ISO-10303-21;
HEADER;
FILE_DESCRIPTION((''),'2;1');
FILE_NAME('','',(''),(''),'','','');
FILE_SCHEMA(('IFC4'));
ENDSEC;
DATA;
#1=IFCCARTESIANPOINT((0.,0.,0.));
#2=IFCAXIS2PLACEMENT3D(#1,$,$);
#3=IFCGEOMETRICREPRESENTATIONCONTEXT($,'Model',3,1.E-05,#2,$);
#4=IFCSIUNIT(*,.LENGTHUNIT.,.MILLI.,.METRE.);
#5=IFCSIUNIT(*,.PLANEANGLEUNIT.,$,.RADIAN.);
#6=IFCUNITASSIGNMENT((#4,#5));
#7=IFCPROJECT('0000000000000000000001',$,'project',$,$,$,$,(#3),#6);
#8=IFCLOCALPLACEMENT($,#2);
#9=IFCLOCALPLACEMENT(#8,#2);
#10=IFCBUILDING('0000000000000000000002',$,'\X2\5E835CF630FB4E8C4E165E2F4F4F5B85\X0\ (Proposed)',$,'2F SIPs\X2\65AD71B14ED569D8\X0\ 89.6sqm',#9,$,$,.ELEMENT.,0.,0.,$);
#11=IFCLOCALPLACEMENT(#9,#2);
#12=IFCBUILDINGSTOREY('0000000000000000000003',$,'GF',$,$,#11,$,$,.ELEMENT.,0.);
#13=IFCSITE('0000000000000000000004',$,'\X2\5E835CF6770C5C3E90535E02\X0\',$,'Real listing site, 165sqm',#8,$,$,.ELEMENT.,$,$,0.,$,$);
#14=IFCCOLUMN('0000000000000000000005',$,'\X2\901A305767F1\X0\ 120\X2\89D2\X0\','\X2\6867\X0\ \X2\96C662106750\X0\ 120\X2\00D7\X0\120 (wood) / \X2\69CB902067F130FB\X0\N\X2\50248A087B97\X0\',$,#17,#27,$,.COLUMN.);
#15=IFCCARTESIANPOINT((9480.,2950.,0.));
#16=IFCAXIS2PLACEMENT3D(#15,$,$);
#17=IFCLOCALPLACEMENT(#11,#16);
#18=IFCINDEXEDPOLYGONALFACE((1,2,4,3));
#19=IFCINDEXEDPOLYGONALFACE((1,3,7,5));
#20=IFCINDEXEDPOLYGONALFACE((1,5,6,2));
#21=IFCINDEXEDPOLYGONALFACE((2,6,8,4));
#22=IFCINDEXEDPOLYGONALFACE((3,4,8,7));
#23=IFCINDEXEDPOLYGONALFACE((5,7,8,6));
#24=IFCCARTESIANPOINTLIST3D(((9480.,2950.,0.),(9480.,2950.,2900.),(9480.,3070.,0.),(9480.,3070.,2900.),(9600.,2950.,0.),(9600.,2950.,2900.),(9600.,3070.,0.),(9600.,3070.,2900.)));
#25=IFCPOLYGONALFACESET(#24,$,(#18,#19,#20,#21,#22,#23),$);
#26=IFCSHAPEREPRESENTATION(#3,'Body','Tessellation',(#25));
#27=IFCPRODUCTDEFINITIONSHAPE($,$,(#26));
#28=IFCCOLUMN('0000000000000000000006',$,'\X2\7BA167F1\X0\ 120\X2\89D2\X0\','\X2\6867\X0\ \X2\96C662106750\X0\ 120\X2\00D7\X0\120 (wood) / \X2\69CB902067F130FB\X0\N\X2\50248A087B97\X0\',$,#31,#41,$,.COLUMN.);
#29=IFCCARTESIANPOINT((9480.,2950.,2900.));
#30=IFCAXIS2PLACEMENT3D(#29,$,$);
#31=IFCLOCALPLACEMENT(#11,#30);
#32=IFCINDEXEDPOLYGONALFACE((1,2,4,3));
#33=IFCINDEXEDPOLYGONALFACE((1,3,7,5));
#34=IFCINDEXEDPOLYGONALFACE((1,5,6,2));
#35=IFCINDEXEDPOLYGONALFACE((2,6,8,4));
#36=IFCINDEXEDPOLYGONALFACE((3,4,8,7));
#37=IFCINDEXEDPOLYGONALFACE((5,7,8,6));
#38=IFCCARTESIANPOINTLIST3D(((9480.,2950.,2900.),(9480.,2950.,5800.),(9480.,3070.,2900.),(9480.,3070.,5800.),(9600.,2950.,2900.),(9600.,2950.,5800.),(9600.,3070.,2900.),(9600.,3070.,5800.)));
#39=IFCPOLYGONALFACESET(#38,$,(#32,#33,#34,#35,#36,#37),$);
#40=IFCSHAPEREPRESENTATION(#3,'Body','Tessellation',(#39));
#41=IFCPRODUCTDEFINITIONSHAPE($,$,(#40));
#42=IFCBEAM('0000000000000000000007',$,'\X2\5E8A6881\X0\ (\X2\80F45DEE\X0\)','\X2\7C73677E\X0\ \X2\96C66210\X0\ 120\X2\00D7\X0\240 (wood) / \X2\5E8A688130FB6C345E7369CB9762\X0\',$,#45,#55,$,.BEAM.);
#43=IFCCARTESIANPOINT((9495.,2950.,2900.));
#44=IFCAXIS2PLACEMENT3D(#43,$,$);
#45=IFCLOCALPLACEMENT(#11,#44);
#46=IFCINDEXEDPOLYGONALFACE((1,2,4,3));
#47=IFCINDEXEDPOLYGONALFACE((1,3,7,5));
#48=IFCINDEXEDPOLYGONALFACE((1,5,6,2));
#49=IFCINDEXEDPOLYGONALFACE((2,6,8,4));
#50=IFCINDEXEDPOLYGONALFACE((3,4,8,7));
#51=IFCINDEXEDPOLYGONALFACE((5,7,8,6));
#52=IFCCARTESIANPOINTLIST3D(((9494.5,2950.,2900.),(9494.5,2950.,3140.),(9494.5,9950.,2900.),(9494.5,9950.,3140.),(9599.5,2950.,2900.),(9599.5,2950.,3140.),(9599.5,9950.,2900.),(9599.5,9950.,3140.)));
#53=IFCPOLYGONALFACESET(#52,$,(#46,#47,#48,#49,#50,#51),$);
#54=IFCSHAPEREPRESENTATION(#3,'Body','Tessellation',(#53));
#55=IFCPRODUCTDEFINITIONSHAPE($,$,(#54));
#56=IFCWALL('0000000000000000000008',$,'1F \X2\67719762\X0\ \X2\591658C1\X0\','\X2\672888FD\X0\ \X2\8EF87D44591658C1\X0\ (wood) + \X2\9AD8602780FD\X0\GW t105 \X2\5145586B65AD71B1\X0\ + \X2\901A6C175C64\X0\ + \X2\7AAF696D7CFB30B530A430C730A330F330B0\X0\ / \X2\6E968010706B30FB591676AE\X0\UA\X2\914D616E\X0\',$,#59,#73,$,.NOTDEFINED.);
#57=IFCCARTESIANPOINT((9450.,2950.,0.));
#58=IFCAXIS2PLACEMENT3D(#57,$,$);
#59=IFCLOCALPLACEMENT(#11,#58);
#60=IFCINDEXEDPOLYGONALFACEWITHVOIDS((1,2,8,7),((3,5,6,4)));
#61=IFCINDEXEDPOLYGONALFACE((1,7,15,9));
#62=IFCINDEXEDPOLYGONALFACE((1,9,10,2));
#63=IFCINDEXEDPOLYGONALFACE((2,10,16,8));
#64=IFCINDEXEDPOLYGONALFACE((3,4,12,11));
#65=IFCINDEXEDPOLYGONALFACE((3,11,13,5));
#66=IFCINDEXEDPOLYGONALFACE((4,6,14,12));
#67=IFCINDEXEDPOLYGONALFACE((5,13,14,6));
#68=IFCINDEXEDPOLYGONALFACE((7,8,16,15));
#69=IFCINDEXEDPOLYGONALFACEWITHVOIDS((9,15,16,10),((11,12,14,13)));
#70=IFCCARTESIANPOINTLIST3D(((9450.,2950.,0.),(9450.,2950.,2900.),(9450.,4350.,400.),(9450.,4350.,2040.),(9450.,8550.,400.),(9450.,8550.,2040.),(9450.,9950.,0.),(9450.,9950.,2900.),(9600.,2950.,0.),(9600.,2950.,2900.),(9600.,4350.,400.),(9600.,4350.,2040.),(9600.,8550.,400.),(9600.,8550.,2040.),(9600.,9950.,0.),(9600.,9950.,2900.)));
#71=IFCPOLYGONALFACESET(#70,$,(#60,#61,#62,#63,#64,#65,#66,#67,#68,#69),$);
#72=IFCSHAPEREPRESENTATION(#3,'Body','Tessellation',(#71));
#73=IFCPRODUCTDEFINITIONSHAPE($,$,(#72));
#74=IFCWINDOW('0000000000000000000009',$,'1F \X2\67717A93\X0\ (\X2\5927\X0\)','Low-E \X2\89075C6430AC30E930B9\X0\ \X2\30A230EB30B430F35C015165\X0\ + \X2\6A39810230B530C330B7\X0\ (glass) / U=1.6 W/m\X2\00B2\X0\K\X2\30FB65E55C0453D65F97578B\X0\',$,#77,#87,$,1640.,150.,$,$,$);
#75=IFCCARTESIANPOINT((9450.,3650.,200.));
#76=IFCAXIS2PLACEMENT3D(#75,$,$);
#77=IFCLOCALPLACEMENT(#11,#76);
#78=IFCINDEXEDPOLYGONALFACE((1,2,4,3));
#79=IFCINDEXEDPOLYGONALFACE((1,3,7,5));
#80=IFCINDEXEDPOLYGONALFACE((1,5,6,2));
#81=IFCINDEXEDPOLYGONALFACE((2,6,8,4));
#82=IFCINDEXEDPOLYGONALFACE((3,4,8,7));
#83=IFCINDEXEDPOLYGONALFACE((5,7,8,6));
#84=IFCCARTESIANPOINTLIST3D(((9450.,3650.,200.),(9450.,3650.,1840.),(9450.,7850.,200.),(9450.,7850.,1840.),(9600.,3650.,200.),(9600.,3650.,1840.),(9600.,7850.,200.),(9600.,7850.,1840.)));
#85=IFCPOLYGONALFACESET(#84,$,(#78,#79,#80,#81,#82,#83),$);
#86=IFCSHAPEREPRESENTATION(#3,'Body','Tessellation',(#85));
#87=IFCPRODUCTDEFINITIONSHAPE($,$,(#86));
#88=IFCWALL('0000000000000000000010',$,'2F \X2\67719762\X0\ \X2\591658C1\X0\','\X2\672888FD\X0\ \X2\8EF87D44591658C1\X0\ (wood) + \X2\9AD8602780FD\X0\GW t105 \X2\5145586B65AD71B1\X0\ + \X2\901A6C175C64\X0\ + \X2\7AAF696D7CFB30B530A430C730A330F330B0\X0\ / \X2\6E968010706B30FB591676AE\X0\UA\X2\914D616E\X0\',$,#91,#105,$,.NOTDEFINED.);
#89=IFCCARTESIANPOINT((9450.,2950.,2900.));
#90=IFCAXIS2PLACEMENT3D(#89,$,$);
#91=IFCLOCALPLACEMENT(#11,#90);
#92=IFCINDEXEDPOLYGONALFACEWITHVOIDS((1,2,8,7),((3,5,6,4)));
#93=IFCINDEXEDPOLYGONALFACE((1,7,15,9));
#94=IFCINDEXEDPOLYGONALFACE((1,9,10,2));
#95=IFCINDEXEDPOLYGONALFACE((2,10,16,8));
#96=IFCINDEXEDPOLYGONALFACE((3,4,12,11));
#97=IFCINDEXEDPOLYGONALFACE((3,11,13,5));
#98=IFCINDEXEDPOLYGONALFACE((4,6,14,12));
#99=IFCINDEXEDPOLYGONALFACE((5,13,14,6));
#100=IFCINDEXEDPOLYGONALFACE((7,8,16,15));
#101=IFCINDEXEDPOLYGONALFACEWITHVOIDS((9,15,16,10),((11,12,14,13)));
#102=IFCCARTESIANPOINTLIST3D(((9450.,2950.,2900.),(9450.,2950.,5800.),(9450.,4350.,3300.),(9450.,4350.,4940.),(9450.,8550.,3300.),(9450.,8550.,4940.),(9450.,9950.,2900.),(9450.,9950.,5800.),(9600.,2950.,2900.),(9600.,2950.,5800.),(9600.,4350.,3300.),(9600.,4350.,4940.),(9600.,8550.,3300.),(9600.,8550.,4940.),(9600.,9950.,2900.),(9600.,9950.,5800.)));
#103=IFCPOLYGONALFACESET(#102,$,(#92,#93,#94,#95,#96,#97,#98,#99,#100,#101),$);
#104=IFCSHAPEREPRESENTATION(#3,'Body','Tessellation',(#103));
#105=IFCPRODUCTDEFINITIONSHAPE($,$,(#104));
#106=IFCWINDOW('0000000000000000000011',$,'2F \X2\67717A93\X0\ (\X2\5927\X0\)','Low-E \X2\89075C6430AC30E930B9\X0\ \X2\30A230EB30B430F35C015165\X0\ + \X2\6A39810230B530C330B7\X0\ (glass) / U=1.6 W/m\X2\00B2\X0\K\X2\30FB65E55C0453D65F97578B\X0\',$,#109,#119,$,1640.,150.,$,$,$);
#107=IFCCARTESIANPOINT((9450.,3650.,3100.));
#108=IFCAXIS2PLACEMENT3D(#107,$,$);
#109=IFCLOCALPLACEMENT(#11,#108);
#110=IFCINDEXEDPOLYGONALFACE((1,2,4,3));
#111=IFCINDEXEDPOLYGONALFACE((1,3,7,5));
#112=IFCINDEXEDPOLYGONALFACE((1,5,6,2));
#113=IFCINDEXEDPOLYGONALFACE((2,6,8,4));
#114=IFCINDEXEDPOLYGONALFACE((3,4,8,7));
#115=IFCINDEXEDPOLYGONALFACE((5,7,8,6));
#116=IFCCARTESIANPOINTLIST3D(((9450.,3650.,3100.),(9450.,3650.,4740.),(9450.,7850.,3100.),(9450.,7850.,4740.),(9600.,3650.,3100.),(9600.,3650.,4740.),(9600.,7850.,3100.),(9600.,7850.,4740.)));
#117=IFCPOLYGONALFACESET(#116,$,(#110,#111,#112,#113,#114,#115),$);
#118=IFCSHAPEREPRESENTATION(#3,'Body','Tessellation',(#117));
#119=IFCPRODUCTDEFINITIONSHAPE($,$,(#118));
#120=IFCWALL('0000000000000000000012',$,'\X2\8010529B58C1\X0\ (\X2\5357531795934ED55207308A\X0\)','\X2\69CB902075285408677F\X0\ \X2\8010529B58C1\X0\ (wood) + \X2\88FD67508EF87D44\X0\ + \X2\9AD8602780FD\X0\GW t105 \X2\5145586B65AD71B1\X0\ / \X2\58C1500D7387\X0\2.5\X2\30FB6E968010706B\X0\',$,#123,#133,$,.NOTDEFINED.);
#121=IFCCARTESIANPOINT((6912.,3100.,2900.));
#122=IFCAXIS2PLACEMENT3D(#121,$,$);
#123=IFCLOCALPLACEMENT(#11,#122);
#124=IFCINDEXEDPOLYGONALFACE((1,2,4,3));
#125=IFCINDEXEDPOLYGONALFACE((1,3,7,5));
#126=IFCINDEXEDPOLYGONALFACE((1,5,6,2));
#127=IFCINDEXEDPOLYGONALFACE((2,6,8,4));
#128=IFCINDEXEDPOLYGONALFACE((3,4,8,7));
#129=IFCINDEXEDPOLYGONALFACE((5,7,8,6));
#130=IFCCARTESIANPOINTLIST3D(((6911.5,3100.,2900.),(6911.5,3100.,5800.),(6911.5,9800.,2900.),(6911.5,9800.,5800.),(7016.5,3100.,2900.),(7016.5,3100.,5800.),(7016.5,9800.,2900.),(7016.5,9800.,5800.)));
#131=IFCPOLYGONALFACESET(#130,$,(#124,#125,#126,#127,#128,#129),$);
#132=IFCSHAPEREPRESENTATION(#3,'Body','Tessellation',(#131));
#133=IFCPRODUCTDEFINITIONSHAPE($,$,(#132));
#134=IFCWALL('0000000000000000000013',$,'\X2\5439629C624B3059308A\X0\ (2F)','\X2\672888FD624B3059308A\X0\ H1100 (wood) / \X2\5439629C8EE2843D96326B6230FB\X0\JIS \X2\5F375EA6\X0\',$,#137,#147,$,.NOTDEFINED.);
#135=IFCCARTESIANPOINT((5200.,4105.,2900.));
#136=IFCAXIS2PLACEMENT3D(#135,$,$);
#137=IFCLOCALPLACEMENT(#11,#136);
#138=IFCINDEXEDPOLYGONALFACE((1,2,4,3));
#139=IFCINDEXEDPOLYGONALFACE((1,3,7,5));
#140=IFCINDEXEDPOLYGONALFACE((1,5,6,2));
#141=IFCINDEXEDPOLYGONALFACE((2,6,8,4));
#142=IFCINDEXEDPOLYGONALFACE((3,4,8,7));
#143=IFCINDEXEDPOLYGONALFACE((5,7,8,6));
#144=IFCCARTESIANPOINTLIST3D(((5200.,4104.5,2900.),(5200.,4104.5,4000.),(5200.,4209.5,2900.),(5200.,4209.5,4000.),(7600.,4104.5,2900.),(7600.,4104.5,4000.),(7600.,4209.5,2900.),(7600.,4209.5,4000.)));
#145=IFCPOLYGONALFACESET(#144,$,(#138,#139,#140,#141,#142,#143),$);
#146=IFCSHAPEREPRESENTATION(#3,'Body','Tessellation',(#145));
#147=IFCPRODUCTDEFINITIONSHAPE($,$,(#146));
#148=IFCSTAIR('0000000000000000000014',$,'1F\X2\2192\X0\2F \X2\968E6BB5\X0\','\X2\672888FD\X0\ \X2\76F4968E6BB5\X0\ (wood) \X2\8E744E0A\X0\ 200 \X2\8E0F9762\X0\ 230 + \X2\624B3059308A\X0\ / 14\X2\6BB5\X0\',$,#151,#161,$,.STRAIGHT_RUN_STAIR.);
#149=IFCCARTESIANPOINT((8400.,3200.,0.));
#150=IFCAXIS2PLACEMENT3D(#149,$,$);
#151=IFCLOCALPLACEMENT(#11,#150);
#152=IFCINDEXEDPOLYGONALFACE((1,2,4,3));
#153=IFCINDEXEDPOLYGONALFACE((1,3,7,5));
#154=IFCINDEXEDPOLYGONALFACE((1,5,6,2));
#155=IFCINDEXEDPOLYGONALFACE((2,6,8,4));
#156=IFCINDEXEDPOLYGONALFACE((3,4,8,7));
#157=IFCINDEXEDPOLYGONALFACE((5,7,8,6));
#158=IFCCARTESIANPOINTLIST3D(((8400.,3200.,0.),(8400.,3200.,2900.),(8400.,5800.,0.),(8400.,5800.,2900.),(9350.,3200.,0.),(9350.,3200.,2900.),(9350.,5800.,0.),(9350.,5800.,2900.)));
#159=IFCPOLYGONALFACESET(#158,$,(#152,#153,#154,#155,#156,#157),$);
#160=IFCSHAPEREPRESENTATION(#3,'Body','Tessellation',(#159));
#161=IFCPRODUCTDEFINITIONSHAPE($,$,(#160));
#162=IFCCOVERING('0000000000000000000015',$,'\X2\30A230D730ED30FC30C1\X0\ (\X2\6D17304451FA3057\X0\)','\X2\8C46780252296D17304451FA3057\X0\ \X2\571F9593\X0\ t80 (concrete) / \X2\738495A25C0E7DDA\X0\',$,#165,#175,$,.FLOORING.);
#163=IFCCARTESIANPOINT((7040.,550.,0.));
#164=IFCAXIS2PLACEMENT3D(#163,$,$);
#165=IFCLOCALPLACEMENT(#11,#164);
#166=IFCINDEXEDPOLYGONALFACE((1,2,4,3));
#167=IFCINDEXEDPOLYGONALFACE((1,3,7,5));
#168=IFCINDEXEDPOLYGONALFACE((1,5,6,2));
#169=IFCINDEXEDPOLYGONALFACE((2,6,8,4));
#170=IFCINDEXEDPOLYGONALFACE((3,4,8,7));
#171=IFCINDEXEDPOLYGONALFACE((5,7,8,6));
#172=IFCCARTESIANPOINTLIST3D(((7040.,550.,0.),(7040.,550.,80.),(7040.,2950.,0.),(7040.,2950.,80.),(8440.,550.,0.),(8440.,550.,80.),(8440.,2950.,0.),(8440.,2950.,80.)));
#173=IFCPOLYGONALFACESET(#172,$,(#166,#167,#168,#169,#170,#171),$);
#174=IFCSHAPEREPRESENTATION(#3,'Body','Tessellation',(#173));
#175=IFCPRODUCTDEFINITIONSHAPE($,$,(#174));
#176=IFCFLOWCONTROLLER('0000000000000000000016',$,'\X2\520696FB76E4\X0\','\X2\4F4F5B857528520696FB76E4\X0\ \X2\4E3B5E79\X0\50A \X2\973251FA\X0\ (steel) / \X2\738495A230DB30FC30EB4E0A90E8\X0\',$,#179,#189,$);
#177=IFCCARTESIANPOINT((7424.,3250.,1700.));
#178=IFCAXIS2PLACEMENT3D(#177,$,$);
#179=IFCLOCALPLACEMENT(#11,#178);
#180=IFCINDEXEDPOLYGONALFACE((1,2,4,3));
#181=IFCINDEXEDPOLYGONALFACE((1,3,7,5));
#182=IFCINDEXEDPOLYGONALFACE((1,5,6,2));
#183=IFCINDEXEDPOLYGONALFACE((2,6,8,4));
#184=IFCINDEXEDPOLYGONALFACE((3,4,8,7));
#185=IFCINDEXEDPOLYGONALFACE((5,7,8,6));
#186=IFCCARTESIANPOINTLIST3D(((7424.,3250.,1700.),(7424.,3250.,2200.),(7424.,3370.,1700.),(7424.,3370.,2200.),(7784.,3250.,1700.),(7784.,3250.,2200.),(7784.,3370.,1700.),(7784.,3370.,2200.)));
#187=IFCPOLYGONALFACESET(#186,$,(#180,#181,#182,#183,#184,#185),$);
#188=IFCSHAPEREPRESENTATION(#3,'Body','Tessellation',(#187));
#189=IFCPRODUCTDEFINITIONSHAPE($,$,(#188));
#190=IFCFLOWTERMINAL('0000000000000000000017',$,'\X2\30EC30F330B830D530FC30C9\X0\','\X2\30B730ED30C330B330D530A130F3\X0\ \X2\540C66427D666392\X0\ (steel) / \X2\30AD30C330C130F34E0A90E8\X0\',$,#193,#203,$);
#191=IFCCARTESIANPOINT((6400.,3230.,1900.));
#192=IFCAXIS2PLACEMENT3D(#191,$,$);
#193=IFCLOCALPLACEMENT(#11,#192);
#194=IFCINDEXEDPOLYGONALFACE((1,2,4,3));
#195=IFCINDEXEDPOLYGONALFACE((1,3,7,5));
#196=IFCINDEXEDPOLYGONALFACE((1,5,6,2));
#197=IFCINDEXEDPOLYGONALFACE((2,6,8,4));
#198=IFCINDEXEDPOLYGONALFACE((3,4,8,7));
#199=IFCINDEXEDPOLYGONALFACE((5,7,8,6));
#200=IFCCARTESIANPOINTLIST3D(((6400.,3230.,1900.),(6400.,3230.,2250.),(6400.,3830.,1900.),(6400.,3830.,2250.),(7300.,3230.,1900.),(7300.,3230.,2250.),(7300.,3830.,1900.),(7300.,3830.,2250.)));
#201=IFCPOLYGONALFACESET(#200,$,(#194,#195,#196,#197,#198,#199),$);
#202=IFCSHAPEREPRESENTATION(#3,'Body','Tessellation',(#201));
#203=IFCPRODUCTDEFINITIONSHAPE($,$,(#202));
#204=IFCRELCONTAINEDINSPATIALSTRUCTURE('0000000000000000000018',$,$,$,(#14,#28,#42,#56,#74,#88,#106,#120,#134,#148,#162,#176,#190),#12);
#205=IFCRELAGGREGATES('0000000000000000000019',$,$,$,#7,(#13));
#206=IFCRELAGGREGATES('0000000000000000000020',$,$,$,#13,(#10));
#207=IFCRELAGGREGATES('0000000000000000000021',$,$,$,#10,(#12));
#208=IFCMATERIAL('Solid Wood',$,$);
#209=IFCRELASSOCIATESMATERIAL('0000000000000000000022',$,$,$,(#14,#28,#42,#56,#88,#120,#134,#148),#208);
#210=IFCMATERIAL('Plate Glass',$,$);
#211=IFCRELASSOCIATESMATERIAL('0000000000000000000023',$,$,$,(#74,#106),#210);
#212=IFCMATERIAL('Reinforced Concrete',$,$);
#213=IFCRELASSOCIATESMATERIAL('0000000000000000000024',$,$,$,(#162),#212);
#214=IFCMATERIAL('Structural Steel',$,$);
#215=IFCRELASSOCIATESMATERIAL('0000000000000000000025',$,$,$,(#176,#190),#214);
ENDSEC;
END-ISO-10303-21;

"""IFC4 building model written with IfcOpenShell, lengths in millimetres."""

from ifc_helpers import new_model, si_unit, frame, frame_2d, origin, place, context, project, spatial, rectangle, extrude, material, element, fill, save


model = new_model("IFC4")

# Units and contexts
model_context = context("Model", 3, precision=1e-05, world=origin())
ifc_project = project(units=[si_unit("LENGTHUNIT", "METRE", prefix="MILLI"), si_unit("PLANEANGLEUNIT", "RADIAN")], contexts=[model_context])

# Site, building, storey
site_placement = place(None, origin())
site = spatial("IfcSite", under=ifc_project, at=site_placement, Name="広島県尾道市", ObjectType="Real listing site, 165sqm", CompositionType="ELEMENT", RefElevation=0.0)
building_placement = place(site_placement, origin())
building = spatial("IfcBuilding", under=site, at=building_placement, Name="広島・二世帯住宅 (Proposed)", ObjectType="2F SIPs断熱仕様 89.6sqm", CompositionType="ELEMENT", ElevationOfRefHeight=0.0, ElevationOfTerrain=0.0)
storey_placement = place(building_placement, origin())
storey = spatial("IfcBuildingStorey", under=building, at=storey_placement, Name="GF", CompositionType="ELEMENT", Elevation=0.0)

# Columns
ifc_material_1 = material(Name="Solid Wood")
column_1_placement = place(storey_placement, frame((9480.0, 2950.0, 0.0)))
element("IfcColumn", 1, at=column_1_placement, inside=storey, material=ifc_material_1, Name="通し柱 120角", Description="桧 集成材 120×120 (wood) / 構造柱・N値計算", PredefinedType="COLUMN", context=model_context, shape_type="SweptSolid", body=[
    extrude(rectangle(XDim=120.0, YDim=120.0, at=frame_2d((60.0, 60.0))), frame((9480.0, 2950.0, 0.0)), (0.0, 0.0, 1.0), 2900.0),
])
column_2_placement = place(storey_placement, frame((9480.0, 2950.0, 2900.0)))
element("IfcColumn", 2, at=column_2_placement, inside=storey, material=ifc_material_1, Name="管柱 120角", Description="桧 集成材 120×120 (wood) / 構造柱・N値計算", PredefinedType="COLUMN", context=model_context, shape_type="SweptSolid", body=[
    extrude(rectangle(XDim=120.0, YDim=120.0, at=frame_2d((60.0, 60.0))), frame((9480.0, 2950.0, 2900.0)), (0.0, 0.0, 1.0), 2900.0),
])

# Beam
beam_1_placement = place(storey_placement, frame((9495.0, 2950.0, 2900.0)))
element("IfcBeam", 3, at=beam_1_placement, inside=storey, material=ifc_material_1, Name="床梁 (胴差)", Description="米松 集成 120×240 (wood) / 床梁・水平構面", PredefinedType="BEAM", context=model_context, shape_type="SweptSolid", body=[
    extrude(rectangle(XDim=105.0, YDim=7000.0, at=frame_2d((52.0, 3500.0))), frame((9495.0, 2950.0, 2900.0)), (0.0, 0.0, 1.0), 240.0),
])

# Wall, opening, window
wall_1_placement = place(storey_placement, frame((9450.0, 2950.0, 0.0)))
wall_1 = element("IfcWall", 4, at=wall_1_placement, inside=storey, material=ifc_material_1, Name="1F 東面 外壁", Description="木製 軸組外壁 (wood) + 高性能GW t105 充填断熱 + 通気層 + 窯業系サイディング / 準耐火・外皮UA配慮", PredefinedType="NOTDEFINED", context=model_context, shape_type="SweptSolid", body=[
    extrude(rectangle(XDim=150.0, YDim=7000.0, at=frame_2d((75.0, 3500.0))), frame((9450.0, 2950.0, 0.0)), (0.0, 0.0, 1.0), 2900.0),
])
opening_1_placement = place(storey_placement, frame((9450.0, 3650.0, 200.0)))
opening_1 = element("IfcOpeningElement", 5, at=opening_1_placement, cuts=wall_1, PredefinedType="NOTDEFINED", context=model_context, shape_type="SweptSolid", body=[
    extrude(rectangle(XDim=150.0, YDim=4200.0, at=frame_2d((75.0, 2100.0))), frame((9450.0, 3650.0, 200.0)), (0.0, 0.0, 1.0), 1640.0),
])
ifc_material_2 = material(Name="Plate Glass")
window_1_placement = place(storey_placement, frame((9450.0, 3650.0, 200.0)))
window_1 = element("IfcWindow", 6, at=window_1_placement, inside=storey, material=ifc_material_2, Name="1F 東窓 (大)", Description="Low-E 複層ガラス アルゴン封入 + 樹脂サッシ (glass) / U=1.6 W/m²K・日射取得型", OverallHeight=1640.0, OverallWidth=150.0, context=model_context, shape_type="SweptSolid", body=[
    extrude(rectangle(XDim=150.0, YDim=4200.0, at=frame_2d((75.0, 2100.0))), frame((9450.0, 3650.0, 200.0)), (0.0, 0.0, 1.0), 1640.0),
])
fill(opening_1, window_1)

# Wall, opening, window
wall_2_placement = place(storey_placement, frame((9450.0, 2950.0, 2900.0)))
wall_2 = element("IfcWall", 7, at=wall_2_placement, inside=storey, material=ifc_material_1, Name="2F 東面 外壁", Description="木製 軸組外壁 (wood) + 高性能GW t105 充填断熱 + 通気層 + 窯業系サイディング / 準耐火・外皮UA配慮", PredefinedType="NOTDEFINED", context=model_context, shape_type="SweptSolid", body=[
    extrude(rectangle(XDim=150.0, YDim=7000.0, at=frame_2d((75.0, 3500.0))), frame((9450.0, 2950.0, 2900.0)), (0.0, 0.0, 1.0), 2900.0),
])
opening_2_placement = place(storey_placement, frame((9450.0, 3650.0, 3100.0)))
opening_2 = element("IfcOpeningElement", 8, at=opening_2_placement, cuts=wall_2, PredefinedType="NOTDEFINED", context=model_context, shape_type="SweptSolid", body=[
    extrude(rectangle(XDim=150.0, YDim=4200.0, at=frame_2d((75.0, 2100.0))), frame((9450.0, 3650.0, 3100.0)), (0.0, 0.0, 1.0), 1640.0),
])
window_2_placement = place(storey_placement, frame((9450.0, 3650.0, 3100.0)))
window_2 = element("IfcWindow", 9, at=window_2_placement, inside=storey, material=ifc_material_2, Name="2F 東窓 (大)", Description="Low-E 複層ガラス アルゴン封入 + 樹脂サッシ (glass) / U=1.6 W/m²K・日射取得型", OverallHeight=1640.0, OverallWidth=150.0, context=model_context, shape_type="SweptSolid", body=[
    extrude(rectangle(XDim=150.0, YDim=4200.0, at=frame_2d((75.0, 2100.0))), frame((9450.0, 3650.0, 3100.0)), (0.0, 0.0, 1.0), 1640.0),
])
fill(opening_2, window_2)

# Walls
wall_3_placement = place(storey_placement, frame((6912.0, 3100.0, 2900.0)))
element("IfcWall", 10, at=wall_3_placement, inside=storey, material=ifc_material_1, Name="耐力壁 (南北間仕切り)", Description="構造用合板 耐力壁 (wood) + 製材軸組 + 高性能GW t105 充填断熱 / 壁倍率2.5・準耐火", PredefinedType="NOTDEFINED", context=model_context, shape_type="SweptSolid", body=[
    extrude(rectangle(XDim=105.0, YDim=6700.0, at=frame_2d((52.0, 3350.0))), frame((6912.0, 3100.0, 2900.0)), (0.0, 0.0, 1.0), 2900.0),
])
wall_4_placement = place(storey_placement, frame((5200.0, 4105.0, 2900.0)))
element("IfcWall", 11, at=wall_4_placement, inside=storey, material=ifc_material_1, Name="吹抜手すり (2F)", Description="木製手すり H1100 (wood) / 吹抜転落防止・JIS 強度", PredefinedType="NOTDEFINED", context=model_context, shape_type="SweptSolid", body=[
    extrude(rectangle(XDim=2400.0, YDim=105.0, at=frame_2d((1200.0, 52.0))), frame((5200.0, 4105.0, 2900.0)), (0.0, 0.0, 1.0), 1100.0),
])

# Stair
stair_placement = place(storey_placement, frame((8400.0, 3200.0, 0.0)))
element("IfcStair", 12, at=stair_placement, inside=storey, material=ifc_material_1, Name="1F→2F 階段", Description="木製 直階段 (wood) 蹴上 200 踏面 230 + 手すり / 14段", PredefinedType="STRAIGHT_RUN_STAIR", context=model_context, shape_type="SweptSolid", body=[
    extrude(rectangle(XDim=950.0, YDim=2600.0, at=frame_2d((475.0, 1300.0))), frame((8400.0, 3200.0, 0.0)), (0.0, 0.0, 1.0), 2900.0),
])

# Covering
ifc_material_3 = material(Name="Reinforced Concrete")
covering_placement = place(storey_placement, frame((7040.0, 550.0, 0.0)))
element("IfcCovering", 13, at=covering_placement, inside=storey, material=ifc_material_3, Name="アプローチ (洗い出し)", Description="豆砂利洗い出し 土間 t80 (concrete) / 玄関導線", PredefinedType="FLOORING", context=model_context, shape_type="SweptSolid", body=[
    extrude(rectangle(XDim=1400.0, YDim=2400.0, at=frame_2d((700.0, 1200.0))), frame((7040.0, 550.0, 0.0)), (0.0, 0.0, 1.0), 80.0),
])

# Flow controller
ifc_material_4 = material(Name="Structural Steel")
flow_controller_placement = place(storey_placement, frame((7424.0, 3250.0, 1700.0)))
element("IfcFlowController", 14, at=flow_controller_placement, inside=storey, material=ifc_material_4, Name="分電盤", Description="住宅用分電盤 主幹50A 露出 (steel) / 玄関ホール上部", context=model_context, shape_type="SweptSolid", body=[
    extrude(rectangle(XDim=360.0, YDim=120.0, at=frame_2d((180.0, 60.0))), frame((7424.0, 3250.0, 1700.0)), (0.0, 0.0, 1.0), 500.0),
])

# Flow terminal
flow_terminal_1_placement = place(storey_placement, frame((6400.0, 3230.0, 1900.0)))
element("IfcFlowTerminal", 15, at=flow_terminal_1_placement, inside=storey, material=ifc_material_4, Name="レンジフード", Description="シロッコファン 同時給排 (steel) / キッチン上部", context=model_context, shape_type="SweptSolid", body=[
    extrude(rectangle(XDim=900.0, YDim=600.0, at=frame_2d((450.0, 300.0))), frame((6400.0, 3230.0, 1900.0)), (0.0, 0.0, 1.0), 350.0),
])

save(model, "model.ifc")
